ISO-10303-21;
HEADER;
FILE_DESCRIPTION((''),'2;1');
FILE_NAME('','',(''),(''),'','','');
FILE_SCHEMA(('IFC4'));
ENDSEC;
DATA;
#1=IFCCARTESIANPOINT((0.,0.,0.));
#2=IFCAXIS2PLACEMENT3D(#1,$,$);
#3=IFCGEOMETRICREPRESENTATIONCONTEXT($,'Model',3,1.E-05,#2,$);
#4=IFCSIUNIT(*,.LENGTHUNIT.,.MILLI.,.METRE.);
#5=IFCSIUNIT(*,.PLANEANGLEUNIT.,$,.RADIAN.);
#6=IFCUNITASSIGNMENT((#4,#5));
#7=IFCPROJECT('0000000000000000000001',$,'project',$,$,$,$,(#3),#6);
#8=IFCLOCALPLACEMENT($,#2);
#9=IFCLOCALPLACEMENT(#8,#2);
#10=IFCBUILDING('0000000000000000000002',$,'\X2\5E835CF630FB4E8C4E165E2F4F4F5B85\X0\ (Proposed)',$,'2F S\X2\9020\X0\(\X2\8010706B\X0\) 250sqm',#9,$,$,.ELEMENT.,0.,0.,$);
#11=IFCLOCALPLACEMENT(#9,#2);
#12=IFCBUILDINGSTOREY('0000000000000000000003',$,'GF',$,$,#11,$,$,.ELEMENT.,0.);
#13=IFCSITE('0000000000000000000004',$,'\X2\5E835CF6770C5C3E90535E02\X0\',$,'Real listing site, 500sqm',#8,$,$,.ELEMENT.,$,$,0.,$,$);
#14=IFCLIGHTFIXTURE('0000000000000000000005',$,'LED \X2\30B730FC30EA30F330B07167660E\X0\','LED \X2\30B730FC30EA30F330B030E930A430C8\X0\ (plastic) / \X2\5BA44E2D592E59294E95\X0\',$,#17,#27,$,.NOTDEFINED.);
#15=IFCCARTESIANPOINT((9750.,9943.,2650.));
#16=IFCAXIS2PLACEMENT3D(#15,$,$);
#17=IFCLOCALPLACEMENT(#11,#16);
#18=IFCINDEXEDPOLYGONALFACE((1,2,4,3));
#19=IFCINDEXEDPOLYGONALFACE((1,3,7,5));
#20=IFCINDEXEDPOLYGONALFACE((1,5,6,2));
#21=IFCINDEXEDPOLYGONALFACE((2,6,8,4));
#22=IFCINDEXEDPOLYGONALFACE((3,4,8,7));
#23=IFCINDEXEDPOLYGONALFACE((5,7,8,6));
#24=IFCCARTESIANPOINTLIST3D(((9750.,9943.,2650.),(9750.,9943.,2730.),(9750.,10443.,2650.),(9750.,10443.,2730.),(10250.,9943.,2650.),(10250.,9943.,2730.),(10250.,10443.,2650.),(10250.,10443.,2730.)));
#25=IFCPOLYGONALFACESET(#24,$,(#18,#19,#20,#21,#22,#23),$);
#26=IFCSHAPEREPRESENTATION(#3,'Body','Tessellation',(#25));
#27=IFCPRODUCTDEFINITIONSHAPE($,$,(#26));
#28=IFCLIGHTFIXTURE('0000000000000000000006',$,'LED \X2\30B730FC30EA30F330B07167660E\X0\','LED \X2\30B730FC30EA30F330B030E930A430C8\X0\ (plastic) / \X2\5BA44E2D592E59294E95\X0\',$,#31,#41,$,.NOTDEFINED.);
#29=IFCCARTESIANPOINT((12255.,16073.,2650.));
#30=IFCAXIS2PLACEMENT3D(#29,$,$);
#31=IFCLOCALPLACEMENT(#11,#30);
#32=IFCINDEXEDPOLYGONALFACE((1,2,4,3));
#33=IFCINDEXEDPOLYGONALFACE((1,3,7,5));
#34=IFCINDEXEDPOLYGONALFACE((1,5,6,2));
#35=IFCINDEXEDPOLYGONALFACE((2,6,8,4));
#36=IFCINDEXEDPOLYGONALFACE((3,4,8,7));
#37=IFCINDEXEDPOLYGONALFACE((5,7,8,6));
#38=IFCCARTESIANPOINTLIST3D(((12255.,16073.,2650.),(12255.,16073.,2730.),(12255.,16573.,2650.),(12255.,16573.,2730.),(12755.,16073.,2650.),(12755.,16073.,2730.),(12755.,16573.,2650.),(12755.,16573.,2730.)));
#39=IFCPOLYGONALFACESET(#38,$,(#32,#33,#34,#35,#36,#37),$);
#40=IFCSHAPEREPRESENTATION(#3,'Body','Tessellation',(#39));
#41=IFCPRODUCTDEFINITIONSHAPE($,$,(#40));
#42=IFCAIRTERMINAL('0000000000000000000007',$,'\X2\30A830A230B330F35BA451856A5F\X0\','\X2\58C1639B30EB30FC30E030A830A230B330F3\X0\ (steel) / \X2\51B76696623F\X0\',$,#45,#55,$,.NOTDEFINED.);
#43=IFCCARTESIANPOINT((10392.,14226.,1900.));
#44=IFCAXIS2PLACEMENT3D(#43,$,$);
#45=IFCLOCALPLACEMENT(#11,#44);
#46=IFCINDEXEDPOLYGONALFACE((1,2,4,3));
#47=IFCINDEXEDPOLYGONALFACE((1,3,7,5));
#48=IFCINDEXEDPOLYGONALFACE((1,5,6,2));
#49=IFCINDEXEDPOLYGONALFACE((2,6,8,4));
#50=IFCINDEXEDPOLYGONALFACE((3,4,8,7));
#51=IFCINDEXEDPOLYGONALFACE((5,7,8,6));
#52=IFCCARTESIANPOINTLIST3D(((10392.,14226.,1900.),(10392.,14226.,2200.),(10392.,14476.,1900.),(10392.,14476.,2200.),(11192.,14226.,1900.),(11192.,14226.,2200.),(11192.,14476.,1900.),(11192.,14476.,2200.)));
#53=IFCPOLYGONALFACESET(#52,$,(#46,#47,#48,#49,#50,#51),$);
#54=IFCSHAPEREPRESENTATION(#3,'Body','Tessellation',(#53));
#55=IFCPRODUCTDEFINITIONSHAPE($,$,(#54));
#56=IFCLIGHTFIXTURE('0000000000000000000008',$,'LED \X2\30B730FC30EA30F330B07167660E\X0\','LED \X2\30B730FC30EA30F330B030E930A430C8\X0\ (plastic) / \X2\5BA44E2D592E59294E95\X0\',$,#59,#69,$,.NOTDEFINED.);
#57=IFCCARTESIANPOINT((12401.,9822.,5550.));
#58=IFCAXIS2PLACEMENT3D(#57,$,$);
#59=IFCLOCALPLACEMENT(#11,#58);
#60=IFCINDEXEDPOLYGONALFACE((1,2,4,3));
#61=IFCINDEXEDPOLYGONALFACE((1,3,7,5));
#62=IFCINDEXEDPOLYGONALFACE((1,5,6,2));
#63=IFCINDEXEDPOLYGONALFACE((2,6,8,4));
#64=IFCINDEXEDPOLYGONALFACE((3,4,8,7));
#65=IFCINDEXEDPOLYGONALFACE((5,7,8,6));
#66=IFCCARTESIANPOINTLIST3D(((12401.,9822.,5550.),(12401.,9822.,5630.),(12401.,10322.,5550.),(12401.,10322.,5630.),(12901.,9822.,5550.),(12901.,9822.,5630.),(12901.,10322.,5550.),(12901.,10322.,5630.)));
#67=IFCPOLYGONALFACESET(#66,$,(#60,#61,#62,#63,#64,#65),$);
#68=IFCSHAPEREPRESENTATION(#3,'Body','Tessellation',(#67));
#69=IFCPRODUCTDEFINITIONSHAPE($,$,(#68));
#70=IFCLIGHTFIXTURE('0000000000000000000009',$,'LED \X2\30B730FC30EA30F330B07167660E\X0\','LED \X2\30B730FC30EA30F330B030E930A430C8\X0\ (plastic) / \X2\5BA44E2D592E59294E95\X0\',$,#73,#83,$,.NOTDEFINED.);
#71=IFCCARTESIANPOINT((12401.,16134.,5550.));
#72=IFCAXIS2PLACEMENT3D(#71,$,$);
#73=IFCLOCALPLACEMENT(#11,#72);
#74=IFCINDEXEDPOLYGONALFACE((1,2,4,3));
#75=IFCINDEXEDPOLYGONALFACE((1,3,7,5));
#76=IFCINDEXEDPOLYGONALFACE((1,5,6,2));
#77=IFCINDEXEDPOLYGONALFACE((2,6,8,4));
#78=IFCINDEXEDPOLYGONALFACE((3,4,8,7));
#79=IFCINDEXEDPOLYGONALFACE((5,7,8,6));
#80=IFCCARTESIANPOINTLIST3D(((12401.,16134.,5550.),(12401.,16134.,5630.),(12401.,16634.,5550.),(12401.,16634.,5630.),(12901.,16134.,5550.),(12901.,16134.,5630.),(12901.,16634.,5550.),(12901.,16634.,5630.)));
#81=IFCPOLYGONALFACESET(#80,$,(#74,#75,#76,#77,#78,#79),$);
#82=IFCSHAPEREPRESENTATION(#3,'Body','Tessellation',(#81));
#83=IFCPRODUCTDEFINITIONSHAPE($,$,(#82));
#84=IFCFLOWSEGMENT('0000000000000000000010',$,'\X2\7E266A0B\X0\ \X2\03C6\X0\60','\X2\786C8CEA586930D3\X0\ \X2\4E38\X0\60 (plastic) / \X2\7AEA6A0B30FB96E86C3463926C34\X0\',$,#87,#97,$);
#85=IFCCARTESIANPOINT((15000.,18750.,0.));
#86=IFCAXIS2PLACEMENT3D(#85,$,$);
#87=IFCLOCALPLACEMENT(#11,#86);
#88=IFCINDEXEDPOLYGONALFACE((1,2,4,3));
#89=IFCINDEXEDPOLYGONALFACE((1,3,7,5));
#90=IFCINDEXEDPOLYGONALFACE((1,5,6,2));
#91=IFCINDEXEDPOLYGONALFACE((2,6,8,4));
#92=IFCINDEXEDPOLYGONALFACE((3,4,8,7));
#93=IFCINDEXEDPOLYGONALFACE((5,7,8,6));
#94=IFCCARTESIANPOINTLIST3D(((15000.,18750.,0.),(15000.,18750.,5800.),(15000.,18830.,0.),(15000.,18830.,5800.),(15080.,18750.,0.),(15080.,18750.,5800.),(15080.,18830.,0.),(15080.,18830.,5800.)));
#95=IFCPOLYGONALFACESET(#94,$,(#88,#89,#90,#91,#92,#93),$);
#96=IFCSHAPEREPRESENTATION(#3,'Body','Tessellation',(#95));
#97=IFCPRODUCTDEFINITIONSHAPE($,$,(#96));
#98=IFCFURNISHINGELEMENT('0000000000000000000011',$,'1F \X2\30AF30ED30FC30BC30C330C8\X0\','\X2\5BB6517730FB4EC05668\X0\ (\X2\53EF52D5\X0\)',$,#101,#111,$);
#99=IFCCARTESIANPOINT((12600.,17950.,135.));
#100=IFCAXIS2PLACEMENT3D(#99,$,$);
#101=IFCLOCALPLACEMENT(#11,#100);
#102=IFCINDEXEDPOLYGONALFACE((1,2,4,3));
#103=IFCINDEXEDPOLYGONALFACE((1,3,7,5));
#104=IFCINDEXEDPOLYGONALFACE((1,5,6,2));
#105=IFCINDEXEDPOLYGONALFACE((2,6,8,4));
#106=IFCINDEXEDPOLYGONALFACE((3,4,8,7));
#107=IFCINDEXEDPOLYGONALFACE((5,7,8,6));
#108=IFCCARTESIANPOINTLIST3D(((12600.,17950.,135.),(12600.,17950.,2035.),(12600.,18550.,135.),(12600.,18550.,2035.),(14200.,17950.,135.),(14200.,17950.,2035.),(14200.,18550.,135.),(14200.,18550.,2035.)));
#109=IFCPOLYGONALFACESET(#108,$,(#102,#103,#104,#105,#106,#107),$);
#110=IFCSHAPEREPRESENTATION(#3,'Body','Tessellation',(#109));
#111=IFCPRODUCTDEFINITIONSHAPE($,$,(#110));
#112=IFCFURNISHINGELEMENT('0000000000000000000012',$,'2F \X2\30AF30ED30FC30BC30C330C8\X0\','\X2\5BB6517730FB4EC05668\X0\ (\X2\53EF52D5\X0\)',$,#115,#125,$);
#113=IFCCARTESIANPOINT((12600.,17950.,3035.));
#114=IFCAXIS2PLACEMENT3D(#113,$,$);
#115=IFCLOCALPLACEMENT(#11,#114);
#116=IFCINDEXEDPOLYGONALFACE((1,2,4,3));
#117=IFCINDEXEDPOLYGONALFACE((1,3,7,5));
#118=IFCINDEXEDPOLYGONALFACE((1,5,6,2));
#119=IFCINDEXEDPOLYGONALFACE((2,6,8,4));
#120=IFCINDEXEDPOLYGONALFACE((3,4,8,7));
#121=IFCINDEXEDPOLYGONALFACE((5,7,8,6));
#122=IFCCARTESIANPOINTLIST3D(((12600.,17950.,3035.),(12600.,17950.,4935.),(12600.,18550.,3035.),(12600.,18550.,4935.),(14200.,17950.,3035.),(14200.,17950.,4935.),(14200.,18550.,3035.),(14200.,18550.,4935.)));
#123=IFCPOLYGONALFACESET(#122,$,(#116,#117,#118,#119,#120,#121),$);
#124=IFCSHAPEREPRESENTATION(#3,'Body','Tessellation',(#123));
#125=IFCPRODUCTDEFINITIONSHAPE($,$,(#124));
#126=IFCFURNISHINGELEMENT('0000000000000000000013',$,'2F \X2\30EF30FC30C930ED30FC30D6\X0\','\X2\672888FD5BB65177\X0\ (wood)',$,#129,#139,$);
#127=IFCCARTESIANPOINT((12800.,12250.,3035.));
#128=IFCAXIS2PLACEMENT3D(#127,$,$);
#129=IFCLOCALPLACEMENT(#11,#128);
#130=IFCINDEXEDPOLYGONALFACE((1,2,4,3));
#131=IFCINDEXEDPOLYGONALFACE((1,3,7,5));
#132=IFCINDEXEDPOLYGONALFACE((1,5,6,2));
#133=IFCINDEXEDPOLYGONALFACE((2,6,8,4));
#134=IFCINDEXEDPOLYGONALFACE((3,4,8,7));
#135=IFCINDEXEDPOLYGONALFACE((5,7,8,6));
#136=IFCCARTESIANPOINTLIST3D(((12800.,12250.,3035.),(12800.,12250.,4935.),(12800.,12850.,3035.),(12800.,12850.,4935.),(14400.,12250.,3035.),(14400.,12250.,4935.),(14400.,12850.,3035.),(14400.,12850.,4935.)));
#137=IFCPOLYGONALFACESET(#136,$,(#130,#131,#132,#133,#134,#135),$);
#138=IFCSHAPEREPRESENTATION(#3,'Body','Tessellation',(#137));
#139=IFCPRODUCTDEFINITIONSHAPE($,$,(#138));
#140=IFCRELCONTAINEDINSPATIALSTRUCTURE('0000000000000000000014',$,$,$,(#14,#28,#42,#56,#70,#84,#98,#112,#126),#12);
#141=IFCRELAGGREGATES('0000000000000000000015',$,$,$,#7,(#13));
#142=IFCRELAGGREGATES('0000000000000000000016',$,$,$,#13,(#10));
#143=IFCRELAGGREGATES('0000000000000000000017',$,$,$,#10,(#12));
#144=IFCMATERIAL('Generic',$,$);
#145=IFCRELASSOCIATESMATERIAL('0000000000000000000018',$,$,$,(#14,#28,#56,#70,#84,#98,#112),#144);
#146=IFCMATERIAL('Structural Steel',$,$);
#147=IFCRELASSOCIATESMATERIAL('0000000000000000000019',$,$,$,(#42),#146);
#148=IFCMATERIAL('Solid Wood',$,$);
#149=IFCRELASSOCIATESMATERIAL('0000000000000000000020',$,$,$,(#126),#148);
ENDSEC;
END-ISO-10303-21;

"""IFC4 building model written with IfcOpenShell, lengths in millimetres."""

from ifc_helpers import new_model, si_unit, frame, frame_2d, origin, place, context, project, spatial, rectangle, extrude, material, element, save


model = new_model("IFC4")

# Units and contexts
model_context = context("Model", 3, precision=1e-05, world=origin())
ifc_project = project(units=[si_unit("LENGTHUNIT", "METRE", prefix="MILLI"), si_unit("PLANEANGLEUNIT", "RADIAN")], contexts=[model_context])

# Site, building, storey
site_placement = place(None, origin())
site = spatial("IfcSite", under=ifc_project, at=site_placement, Name="広島県尾道市", ObjectType="Real listing site, 500sqm", CompositionType="ELEMENT", RefElevation=0.0)
building_placement = place(site_placement, origin())
building = spatial("IfcBuilding", under=site, at=building_placement, Name="広島・二世帯住宅 (Proposed)", ObjectType="2F S造(耐火) 250sqm", CompositionType="ELEMENT", ElevationOfRefHeight=0.0, ElevationOfTerrain=0.0)
storey_placement = place(building_placement, origin())
storey = spatial("IfcBuildingStorey", under=building, at=storey_placement, Name="GF", CompositionType="ELEMENT", Elevation=0.0)

# Shared definitions
ifc_material_1 = material(Name="Solid Wood")

# Shared definitions
ifc_material_2 = material(Name="Structural Steel")

# Shared definitions
ifc_material_3 = material(Name="Generic")

# Light fixtures
light_fixture_1_placement = place(storey_placement, frame((9750.0, 9943.0, 2650.0)))
element("IfcLightFixture", 1, at=light_fixture_1_placement, inside=storey, material=ifc_material_3, Name="LED シーリング照明", Description="LED シーリングライト (plastic) / 室中央天井", PredefinedType="NOTDEFINED", context=model_context, shape_type="SweptSolid", body=[
    extrude(rectangle(XDim=500.0, YDim=500.0, at=frame_2d((250.0, 250.0))), frame((9750.0, 9943.0, 2650.0)), (0.0, 0.0, 1.0), 80.0),
])
light_fixture_2_placement = place(storey_placement, frame((12255.0, 16073.0, 2650.0)))
element("IfcLightFixture", 2, at=light_fixture_2_placement, inside=storey, material=ifc_material_3, Name="LED シーリング照明", Description="LED シーリングライト (plastic) / 室中央天井", PredefinedType="NOTDEFINED", context=model_context, shape_type="SweptSolid", body=[
    extrude(rectangle(XDim=500.0, YDim=500.0, at=frame_2d((250.0, 250.0))), frame((12255.0, 16073.0, 2650.0)), (0.0, 0.0, 1.0), 80.0),
])

# Air terminal
air_terminal_placement = place(storey_placement, frame((10392.0, 14226.0, 1900.0)))
element("IfcAirTerminal", 3, at=air_terminal_placement, inside=storey, material=ifc_material_2, Name="エアコン室内機", Description="壁掛ルームエアコン (steel) / 冷暖房", PredefinedType="NOTDEFINED", context=model_context, shape_type="SweptSolid", body=[
    extrude(rectangle(XDim=800.0, YDim=250.0, at=frame_2d((400.0, 125.0))), frame((10392.0, 14226.0, 1900.0)), (0.0, 0.0, 1.0), 300.0),
])

# Light fixtures
light_fixture_3_placement = place(storey_placement, frame((12401.0, 9822.0, 5550.0)))
element("IfcLightFixture", 4, at=light_fixture_3_placement, inside=storey, material=ifc_material_3, Name="LED シーリング照明", Description="LED シーリングライト (plastic) / 室中央天井", PredefinedType="NOTDEFINED", context=model_context, shape_type="SweptSolid", body=[
    extrude(rectangle(XDim=500.0, YDim=500.0, at=frame_2d((250.0, 250.0))), frame((12401.0, 9822.0, 5550.0)), (0.0, 0.0, 1.0), 80.0),
])
light_fixture_4_placement = place(storey_placement, frame((12401.0, 16134.0, 5550.0)))
element("IfcLightFixture", 5, at=light_fixture_4_placement, inside=storey, material=ifc_material_3, Name="LED シーリング照明", Description="LED シーリングライト (plastic) / 室中央天井", PredefinedType="NOTDEFINED", context=model_context, shape_type="SweptSolid", body=[
    extrude(rectangle(XDim=500.0, YDim=500.0, at=frame_2d((250.0, 250.0))), frame((12401.0, 16134.0, 5550.0)), (0.0, 0.0, 1.0), 80.0),
])

# Flow segment
flow_segment_placement = place(storey_placement, frame((15000.0, 18750.0, 0.0)))
element("IfcFlowSegment", 6, at=flow_segment_placement, inside=storey, material=ifc_material_3, Name="縦樋 φ60", Description="硬質塩ビ 丸60 (plastic) / 竪樋・雨水排水", context=model_context, shape_type="SweptSolid", body=[
    extrude(rectangle(XDim=80.0, YDim=80.0, at=frame_2d((40.0, 40.0))), frame((15000.0, 18750.0, 0.0)), (0.0, 0.0, 1.0), 5800.0),
])

# Furnishing elements
furnishing_1_placement = place(storey_placement, frame((12600.0, 17950.0, 135.0)))
element("IfcFurnishingElement", 7, at=furnishing_1_placement, inside=storey, material=ifc_material_3, Name="1F クローゼット", Description="家具・什器 (可動)", context=model_context, shape_type="SweptSolid", body=[
    extrude(rectangle(XDim=1600.0, YDim=600.0, at=frame_2d((800.0, 300.0))), frame((12600.0, 17950.0, 135.0)), (0.0, 0.0, 1.0), 1900.0),
])
furnishing_2_placement = place(storey_placement, frame((12600.0, 17950.0, 3035.0)))
element("IfcFurnishingElement", 8, at=furnishing_2_placement, inside=storey, material=ifc_material_3, Name="2F クローゼット", Description="家具・什器 (可動)", context=model_context, shape_type="SweptSolid", body=[
    extrude(rectangle(XDim=1600.0, YDim=600.0, at=frame_2d((800.0, 300.0))), frame((12600.0, 17950.0, 3035.0)), (0.0, 0.0, 1.0), 1900.0),
])
furnishing_3_placement = place(storey_placement, frame((12800.0, 12250.0, 3035.0)))
element("IfcFurnishingElement", 9, at=furnishing_3_placement, inside=storey, material=ifc_material_1, Name="2F ワードローブ", Description="木製家具 (wood)", context=model_context, shape_type="SweptSolid", body=[
    extrude(rectangle(XDim=1600.0, YDim=600.0, at=frame_2d((800.0, 300.0))), frame((12800.0, 12250.0, 3035.0)), (0.0, 0.0, 1.0), 1900.0),
])

save(model, "model.ifc")
